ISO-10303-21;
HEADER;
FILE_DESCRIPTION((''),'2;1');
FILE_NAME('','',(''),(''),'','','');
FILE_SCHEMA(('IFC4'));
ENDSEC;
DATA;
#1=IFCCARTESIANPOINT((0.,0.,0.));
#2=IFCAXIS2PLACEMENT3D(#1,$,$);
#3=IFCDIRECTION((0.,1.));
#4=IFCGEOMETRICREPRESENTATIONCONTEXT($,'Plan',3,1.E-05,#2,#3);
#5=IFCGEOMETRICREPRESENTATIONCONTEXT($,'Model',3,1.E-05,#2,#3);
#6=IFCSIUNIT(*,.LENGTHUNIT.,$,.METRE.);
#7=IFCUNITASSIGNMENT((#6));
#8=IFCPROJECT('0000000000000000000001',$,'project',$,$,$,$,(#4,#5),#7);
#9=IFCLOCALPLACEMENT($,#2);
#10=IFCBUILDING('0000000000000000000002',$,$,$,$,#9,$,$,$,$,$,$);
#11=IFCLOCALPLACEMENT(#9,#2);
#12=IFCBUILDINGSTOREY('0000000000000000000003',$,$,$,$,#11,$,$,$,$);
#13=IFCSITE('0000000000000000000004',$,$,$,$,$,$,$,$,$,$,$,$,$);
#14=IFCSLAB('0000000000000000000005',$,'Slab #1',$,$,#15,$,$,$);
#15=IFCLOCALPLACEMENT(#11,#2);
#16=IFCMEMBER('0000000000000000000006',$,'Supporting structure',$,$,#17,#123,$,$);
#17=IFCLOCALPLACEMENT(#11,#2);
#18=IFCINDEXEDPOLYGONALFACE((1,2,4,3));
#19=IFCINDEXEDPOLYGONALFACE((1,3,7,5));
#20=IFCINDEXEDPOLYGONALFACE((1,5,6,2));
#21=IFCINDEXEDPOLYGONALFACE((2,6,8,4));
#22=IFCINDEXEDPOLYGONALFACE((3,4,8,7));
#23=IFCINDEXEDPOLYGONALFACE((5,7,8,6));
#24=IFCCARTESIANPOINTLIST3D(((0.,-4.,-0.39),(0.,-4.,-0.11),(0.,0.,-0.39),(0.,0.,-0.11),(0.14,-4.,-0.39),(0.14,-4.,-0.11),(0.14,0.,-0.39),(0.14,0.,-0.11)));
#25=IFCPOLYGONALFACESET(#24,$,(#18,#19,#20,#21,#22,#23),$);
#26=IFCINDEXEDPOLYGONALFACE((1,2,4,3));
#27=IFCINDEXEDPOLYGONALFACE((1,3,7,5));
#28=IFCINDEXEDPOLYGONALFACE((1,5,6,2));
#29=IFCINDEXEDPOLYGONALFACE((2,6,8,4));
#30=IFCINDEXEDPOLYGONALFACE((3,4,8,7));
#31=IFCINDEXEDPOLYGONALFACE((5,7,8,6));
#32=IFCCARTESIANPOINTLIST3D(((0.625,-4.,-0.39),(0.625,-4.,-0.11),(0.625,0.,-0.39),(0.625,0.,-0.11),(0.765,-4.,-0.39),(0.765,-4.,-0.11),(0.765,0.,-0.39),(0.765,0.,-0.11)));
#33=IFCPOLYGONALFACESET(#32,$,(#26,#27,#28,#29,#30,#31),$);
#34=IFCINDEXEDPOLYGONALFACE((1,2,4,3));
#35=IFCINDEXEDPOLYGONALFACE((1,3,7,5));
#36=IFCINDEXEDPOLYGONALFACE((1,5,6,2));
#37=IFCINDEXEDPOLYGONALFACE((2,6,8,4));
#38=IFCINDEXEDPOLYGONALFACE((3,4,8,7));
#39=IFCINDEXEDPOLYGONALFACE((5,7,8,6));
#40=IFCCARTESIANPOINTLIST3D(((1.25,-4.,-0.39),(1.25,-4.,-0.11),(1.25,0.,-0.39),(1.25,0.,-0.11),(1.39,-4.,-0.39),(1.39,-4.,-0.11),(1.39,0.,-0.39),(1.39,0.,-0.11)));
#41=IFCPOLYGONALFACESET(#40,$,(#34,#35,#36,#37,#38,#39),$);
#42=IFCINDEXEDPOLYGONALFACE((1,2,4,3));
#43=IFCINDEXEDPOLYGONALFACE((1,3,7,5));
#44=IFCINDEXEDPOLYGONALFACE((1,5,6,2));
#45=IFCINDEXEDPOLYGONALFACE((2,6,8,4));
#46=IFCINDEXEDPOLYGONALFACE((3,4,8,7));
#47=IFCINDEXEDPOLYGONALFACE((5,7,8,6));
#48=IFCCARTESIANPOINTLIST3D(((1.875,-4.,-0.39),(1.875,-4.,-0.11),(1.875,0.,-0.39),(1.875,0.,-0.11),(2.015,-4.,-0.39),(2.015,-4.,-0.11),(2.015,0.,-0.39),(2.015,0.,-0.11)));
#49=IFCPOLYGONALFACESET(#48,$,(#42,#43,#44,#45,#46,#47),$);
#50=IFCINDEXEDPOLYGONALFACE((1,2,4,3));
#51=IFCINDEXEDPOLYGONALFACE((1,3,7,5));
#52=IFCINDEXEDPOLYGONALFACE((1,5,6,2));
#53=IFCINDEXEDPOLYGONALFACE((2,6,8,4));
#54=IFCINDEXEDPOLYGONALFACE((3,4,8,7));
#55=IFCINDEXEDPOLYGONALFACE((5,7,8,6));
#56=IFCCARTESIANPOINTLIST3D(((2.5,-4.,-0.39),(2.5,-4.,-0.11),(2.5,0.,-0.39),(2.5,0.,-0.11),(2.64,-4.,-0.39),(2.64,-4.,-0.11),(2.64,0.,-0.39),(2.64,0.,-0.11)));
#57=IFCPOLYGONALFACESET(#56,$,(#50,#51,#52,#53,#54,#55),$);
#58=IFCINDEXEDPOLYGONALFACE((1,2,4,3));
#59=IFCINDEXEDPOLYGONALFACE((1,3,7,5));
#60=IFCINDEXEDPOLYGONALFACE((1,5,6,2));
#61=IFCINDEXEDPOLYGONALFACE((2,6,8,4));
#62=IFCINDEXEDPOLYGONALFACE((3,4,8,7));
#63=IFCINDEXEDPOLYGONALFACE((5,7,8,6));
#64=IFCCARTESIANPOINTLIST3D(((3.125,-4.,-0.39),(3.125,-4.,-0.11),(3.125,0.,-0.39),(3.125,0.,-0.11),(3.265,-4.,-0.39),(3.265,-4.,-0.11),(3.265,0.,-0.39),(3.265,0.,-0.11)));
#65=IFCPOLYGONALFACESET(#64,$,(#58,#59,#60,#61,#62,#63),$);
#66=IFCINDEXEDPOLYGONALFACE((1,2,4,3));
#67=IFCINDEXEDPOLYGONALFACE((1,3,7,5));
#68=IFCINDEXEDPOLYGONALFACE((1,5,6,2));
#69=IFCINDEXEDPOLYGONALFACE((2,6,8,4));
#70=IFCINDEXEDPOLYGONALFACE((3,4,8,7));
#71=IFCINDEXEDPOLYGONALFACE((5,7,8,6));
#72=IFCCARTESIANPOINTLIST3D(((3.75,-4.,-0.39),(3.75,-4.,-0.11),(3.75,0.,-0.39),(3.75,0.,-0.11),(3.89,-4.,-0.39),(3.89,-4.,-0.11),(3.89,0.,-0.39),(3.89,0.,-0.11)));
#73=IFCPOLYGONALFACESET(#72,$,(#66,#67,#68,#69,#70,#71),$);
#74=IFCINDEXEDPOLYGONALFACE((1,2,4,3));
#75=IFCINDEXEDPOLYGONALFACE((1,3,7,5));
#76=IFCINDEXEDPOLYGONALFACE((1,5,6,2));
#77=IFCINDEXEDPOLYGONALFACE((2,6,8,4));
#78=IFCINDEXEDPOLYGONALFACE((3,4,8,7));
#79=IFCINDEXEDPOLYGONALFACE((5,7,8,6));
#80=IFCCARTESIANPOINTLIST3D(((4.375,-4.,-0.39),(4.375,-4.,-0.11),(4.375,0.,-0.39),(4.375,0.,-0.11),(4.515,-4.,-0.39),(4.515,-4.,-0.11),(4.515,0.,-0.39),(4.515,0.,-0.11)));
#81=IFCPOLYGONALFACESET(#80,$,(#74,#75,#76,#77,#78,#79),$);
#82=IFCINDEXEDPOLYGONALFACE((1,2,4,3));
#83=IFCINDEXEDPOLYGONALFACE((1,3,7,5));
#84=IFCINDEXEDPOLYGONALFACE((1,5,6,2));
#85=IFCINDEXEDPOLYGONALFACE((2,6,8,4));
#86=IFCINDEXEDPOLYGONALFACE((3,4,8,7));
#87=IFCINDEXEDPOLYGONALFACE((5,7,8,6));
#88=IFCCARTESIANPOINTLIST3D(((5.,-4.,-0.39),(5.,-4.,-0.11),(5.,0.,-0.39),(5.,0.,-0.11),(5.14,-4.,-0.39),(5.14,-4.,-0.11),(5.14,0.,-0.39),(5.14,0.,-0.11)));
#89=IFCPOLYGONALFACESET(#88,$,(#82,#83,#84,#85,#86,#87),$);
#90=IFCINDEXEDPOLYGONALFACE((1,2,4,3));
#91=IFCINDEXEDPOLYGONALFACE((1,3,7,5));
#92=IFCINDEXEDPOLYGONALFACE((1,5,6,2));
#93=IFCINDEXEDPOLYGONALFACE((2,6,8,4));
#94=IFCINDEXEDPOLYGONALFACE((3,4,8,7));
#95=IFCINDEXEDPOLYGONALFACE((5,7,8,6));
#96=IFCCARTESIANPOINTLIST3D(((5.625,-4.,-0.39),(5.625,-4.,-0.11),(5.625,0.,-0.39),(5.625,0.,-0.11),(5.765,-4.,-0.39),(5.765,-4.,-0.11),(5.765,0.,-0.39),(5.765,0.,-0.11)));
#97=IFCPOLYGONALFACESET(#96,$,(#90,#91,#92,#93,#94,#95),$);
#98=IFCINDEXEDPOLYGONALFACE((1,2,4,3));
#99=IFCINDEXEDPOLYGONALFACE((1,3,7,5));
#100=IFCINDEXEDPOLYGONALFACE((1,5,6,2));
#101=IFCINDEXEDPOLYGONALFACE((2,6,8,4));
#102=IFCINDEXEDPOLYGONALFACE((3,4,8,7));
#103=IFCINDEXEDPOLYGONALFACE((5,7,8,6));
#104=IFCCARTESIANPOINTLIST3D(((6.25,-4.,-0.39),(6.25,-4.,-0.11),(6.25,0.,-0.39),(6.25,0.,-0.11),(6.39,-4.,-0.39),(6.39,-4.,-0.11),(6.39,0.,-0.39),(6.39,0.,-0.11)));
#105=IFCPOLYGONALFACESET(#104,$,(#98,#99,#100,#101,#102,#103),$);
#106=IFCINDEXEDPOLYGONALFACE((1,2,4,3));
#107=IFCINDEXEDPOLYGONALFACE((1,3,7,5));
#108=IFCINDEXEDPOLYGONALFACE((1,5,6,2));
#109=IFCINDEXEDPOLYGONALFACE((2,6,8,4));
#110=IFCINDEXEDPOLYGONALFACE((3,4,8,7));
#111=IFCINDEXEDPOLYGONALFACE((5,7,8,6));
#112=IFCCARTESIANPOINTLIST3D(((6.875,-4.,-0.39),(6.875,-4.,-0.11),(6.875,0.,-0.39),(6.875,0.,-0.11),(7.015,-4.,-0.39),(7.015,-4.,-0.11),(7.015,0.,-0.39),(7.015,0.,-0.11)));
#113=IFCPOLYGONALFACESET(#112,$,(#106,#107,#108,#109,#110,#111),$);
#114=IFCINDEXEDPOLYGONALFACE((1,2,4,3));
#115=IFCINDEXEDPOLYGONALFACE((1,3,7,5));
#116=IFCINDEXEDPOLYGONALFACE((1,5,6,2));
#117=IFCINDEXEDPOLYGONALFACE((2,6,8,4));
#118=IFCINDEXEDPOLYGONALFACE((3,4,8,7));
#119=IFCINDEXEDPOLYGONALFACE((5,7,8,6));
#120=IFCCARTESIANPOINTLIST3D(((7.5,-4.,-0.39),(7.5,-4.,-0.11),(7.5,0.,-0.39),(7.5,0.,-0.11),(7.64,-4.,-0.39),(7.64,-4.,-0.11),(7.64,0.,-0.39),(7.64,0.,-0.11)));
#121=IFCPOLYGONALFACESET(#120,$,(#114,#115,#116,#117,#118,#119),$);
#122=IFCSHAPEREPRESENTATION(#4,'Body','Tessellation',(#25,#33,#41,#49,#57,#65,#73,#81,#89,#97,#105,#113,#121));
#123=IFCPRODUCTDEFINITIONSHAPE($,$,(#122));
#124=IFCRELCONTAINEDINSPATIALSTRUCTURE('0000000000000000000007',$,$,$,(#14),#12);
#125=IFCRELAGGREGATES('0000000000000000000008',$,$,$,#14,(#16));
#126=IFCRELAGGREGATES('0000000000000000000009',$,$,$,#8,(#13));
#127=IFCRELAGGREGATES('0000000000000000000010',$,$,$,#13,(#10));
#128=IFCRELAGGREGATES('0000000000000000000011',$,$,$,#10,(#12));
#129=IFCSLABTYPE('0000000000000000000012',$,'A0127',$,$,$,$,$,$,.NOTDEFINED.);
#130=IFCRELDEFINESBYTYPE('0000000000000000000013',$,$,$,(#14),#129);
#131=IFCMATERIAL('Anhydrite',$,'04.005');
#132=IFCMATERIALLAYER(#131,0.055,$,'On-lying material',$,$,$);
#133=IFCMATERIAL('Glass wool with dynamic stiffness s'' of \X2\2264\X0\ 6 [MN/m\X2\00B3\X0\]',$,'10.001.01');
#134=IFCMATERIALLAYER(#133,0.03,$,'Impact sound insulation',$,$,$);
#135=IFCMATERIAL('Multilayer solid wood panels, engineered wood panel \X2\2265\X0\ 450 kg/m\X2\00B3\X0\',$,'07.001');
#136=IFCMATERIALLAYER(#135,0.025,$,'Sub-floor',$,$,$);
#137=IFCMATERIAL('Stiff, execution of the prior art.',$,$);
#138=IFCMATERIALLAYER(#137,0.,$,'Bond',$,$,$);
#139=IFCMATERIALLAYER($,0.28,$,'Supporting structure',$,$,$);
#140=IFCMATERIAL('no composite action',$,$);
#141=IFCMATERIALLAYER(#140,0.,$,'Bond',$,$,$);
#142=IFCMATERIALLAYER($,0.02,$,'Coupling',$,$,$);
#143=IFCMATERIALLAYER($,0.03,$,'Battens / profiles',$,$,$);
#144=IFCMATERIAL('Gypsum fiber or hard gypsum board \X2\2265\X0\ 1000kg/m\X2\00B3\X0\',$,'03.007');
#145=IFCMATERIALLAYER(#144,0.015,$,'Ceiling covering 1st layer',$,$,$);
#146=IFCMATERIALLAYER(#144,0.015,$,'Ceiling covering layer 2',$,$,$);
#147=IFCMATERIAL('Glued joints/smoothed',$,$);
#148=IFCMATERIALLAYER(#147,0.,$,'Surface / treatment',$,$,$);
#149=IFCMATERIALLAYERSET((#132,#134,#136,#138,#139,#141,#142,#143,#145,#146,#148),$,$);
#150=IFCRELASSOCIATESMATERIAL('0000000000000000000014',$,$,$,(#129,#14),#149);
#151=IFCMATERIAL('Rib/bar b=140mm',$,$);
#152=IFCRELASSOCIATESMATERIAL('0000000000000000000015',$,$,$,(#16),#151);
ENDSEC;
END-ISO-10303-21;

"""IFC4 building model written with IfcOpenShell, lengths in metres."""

from ifc_helpers import new_model, si_unit, direction, frame, frame_2d, origin, place, context, project, spatial, rectangle, extrude, material, layer, layer_set, type_object, element, aggregate, save


model = new_model("IFC4")

# Units and contexts
plan_context = context("Plan", 3, precision=1e-05, world=origin(), true_north=direction((0.0, 1.0)))
model_context = context("Model", 3, precision=1e-05, world=origin(), true_north=direction((0.0, 1.0)))
ifc_project = project(units=[si_unit("LENGTHUNIT", "METRE")], contexts=[plan_context, model_context])

# Site, building, storey
site = spatial("IfcSite", under=ifc_project)
building_placement = place(None, origin())
building = spatial("IfcBuilding", under=site, at=building_placement)
storey_placement = place(building_placement, origin())
storey = spatial("IfcBuildingStorey", under=building, at=storey_placement)

# Slab, member
ifc_material_1 = material(Name="Anhydrite", Category="04.005")
ifc_layer_1 = layer(ifc_material_1, 0.055, Name="On-lying material")
ifc_material_2 = material(Name="Glass wool with dynamic stiffness s' of ≤ 6 [MN/m³]", Category="10.001.01")
ifc_layer_2 = layer(ifc_material_2, 0.03, Name="Impact sound insulation")
ifc_material_3 = material(Name="Multilayer solid wood panels, engineered wood panel ≥ 450 kg/m³", Category="07.001")
ifc_layer_3 = layer(ifc_material_3, 0.025, Name="Sub-floor")
ifc_material_4 = material(Name="Stiff, execution of the prior art.")
ifc_layer_4 = layer(ifc_material_4, 0.0, Name="Bond")
ifc_layer_5 = layer(None, 0.28, Name="Supporting structure")
ifc_material_5 = material(Name="no composite action")
ifc_layer_6 = layer(ifc_material_5, 0.0, Name="Bond")
ifc_layer_7 = layer(None, 0.02, Name="Coupling")
ifc_layer_8 = layer(None, 0.03, Name="Battens / profiles")
ifc_material_6 = material(Name="Gypsum fiber or hard gypsum board ≥ 1000kg/m³", Category="03.007")
ifc_layer_9 = layer(ifc_material_6, 0.015, Name="Ceiling covering 1st layer")
ifc_layer_10 = layer(ifc_material_6, 0.015, Name="Ceiling covering layer 2")
ifc_material_7 = material(Name="Glued joints/smoothed")
ifc_layer_11 = layer(ifc_material_7, 0.0, Name="Surface / treatment")
ifc_layer_set = layer_set([ifc_layer_1, ifc_layer_2, ifc_layer_3, ifc_layer_4, ifc_layer_5, ifc_layer_6, ifc_layer_7, ifc_layer_8, ifc_layer_9, ifc_layer_10, ifc_layer_11])
slab_type = type_object("IfcSlabType", Name="A0127", PredefinedType="NOTDEFINED", material=ifc_layer_set)
slab_placement = place(None, frame((0.0, 0.0, 0.0), z_axis=(0.0, 0.0, -1.0), x_axis=(1.0, 0.0, 0.0)))
slab = element("IfcSlab", 1, at=slab_placement, inside=storey, type_object=slab_type, material=ifc_layer_set, Name="Slab #1")
ifc_material_8 = material(Name="Rib/bar b=140mm")
member_1_placement = place(slab_placement, origin())
member_1 = element("IfcMember", 2, at=member_1_placement, material=ifc_material_8, Name="Supporting structure", context=plan_context, shape_type="SweptSolid", body=[
    extrude(rectangle(XDim=0.14, YDim=0.28, at=frame_2d((0.07, 0.14), x_axis=(1.0, 0.0))), frame((0.0, 4.0, 0.11), z_axis=(0.0, -1.0, 0.0), x_axis=(1.0, 0.0, 0.0)), (0.0, 0.0, 1.0), 4.0),
    extrude(rectangle(XDim=0.14, YDim=0.28, at=frame_2d((0.07, 0.14), x_axis=(1.0, 0.0))), frame((0.625, 4.0, 0.11), z_axis=(0.0, -1.0, 0.0), x_axis=(1.0, 0.0, 0.0)), (0.0, 0.0, 1.0), 4.0),
    extrude(rectangle(XDim=0.14, YDim=0.28, at=frame_2d((0.07, 0.14), x_axis=(1.0, 0.0))), frame((1.25, 4.0, 0.11), z_axis=(0.0, -1.0, 0.0), x_axis=(1.0, 0.0, 0.0)), (0.0, 0.0, 1.0), 4.0),
    extrude(rectangle(XDim=0.14, YDim=0.28, at=frame_2d((0.07, 0.14), x_axis=(1.0, 0.0))), frame((1.875, 4.0, 0.11), z_axis=(0.0, -1.0, 0.0), x_axis=(1.0, 0.0, 0.0)), (0.0, 0.0, 1.0), 4.0),
    extrude(rectangle(XDim=0.14, YDim=0.28, at=frame_2d((0.07, 0.14), x_axis=(1.0, 0.0))), frame((2.5, 4.0, 0.11), z_axis=(0.0, -1.0, 0.0), x_axis=(1.0, 0.0, 0.0)), (0.0, 0.0, 1.0), 4.0),
    extrude(rectangle(XDim=0.14, YDim=0.28, at=frame_2d((0.07, 0.14), x_axis=(1.0, 0.0))), frame((3.125, 4.0, 0.11), z_axis=(0.0, -1.0, 0.0), x_axis=(1.0, 0.0, 0.0)), (0.0, 0.0, 1.0), 4.0),
    extrude(rectangle(XDim=0.14, YDim=0.28, at=frame_2d((0.07, 0.14), x_axis=(1.0, 0.0))), frame((3.75, 4.0, 0.11), z_axis=(0.0, -1.0, 0.0), x_axis=(1.0, 0.0, 0.0)), (0.0, 0.0, 1.0), 4.0),
    extrude(rectangle(XDim=0.14, YDim=0.28, at=frame_2d((0.07, 0.14), x_axis=(1.0, 0.0))), frame((4.375, 4.0, 0.11), z_axis=(0.0, -1.0, 0.0), x_axis=(1.0, 0.0, 0.0)), (0.0, 0.0, 1.0), 4.0),
    extrude(rectangle(XDim=0.14, YDim=0.28, at=frame_2d((0.07, 0.14), x_axis=(1.0, 0.0))), frame((5.0, 4.0, 0.11), z_axis=(0.0, -1.0, 0.0), x_axis=(1.0, 0.0, 0.0)), (0.0, 0.0, 1.0), 4.0),
    extrude(rectangle(XDim=0.14, YDim=0.28, at=frame_2d((0.07, 0.14), x_axis=(1.0, 0.0))), frame((5.625, 4.0, 0.11), z_axis=(0.0, -1.0, 0.0), x_axis=(1.0, 0.0, 0.0)), (0.0, 0.0, 1.0), 4.0),
    extrude(rectangle(XDim=0.14, YDim=0.28, at=frame_2d((0.07, 0.14), x_axis=(1.0, 0.0))), frame((6.25, 4.0, 0.11), z_axis=(0.0, -1.0, 0.0), x_axis=(1.0, 0.0, 0.0)), (0.0, 0.0, 1.0), 4.0),
    extrude(rectangle(XDim=0.14, YDim=0.28, at=frame_2d((0.07, 0.14), x_axis=(1.0, 0.0))), frame((6.875, 4.0, 0.11), z_axis=(0.0, -1.0, 0.0), x_axis=(1.0, 0.0, 0.0)), (0.0, 0.0, 1.0), 4.0),
    extrude(rectangle(XDim=0.14, YDim=0.28, at=frame_2d((0.07, 0.14), x_axis=(1.0, 0.0))), frame((7.5, 4.0, 0.11), z_axis=(0.0, -1.0, 0.0), x_axis=(1.0, 0.0, 0.0)), (0.0, 0.0, 1.0), 4.0),
])
aggregate(slab, [member_1])

save(model, "model.ifc")
